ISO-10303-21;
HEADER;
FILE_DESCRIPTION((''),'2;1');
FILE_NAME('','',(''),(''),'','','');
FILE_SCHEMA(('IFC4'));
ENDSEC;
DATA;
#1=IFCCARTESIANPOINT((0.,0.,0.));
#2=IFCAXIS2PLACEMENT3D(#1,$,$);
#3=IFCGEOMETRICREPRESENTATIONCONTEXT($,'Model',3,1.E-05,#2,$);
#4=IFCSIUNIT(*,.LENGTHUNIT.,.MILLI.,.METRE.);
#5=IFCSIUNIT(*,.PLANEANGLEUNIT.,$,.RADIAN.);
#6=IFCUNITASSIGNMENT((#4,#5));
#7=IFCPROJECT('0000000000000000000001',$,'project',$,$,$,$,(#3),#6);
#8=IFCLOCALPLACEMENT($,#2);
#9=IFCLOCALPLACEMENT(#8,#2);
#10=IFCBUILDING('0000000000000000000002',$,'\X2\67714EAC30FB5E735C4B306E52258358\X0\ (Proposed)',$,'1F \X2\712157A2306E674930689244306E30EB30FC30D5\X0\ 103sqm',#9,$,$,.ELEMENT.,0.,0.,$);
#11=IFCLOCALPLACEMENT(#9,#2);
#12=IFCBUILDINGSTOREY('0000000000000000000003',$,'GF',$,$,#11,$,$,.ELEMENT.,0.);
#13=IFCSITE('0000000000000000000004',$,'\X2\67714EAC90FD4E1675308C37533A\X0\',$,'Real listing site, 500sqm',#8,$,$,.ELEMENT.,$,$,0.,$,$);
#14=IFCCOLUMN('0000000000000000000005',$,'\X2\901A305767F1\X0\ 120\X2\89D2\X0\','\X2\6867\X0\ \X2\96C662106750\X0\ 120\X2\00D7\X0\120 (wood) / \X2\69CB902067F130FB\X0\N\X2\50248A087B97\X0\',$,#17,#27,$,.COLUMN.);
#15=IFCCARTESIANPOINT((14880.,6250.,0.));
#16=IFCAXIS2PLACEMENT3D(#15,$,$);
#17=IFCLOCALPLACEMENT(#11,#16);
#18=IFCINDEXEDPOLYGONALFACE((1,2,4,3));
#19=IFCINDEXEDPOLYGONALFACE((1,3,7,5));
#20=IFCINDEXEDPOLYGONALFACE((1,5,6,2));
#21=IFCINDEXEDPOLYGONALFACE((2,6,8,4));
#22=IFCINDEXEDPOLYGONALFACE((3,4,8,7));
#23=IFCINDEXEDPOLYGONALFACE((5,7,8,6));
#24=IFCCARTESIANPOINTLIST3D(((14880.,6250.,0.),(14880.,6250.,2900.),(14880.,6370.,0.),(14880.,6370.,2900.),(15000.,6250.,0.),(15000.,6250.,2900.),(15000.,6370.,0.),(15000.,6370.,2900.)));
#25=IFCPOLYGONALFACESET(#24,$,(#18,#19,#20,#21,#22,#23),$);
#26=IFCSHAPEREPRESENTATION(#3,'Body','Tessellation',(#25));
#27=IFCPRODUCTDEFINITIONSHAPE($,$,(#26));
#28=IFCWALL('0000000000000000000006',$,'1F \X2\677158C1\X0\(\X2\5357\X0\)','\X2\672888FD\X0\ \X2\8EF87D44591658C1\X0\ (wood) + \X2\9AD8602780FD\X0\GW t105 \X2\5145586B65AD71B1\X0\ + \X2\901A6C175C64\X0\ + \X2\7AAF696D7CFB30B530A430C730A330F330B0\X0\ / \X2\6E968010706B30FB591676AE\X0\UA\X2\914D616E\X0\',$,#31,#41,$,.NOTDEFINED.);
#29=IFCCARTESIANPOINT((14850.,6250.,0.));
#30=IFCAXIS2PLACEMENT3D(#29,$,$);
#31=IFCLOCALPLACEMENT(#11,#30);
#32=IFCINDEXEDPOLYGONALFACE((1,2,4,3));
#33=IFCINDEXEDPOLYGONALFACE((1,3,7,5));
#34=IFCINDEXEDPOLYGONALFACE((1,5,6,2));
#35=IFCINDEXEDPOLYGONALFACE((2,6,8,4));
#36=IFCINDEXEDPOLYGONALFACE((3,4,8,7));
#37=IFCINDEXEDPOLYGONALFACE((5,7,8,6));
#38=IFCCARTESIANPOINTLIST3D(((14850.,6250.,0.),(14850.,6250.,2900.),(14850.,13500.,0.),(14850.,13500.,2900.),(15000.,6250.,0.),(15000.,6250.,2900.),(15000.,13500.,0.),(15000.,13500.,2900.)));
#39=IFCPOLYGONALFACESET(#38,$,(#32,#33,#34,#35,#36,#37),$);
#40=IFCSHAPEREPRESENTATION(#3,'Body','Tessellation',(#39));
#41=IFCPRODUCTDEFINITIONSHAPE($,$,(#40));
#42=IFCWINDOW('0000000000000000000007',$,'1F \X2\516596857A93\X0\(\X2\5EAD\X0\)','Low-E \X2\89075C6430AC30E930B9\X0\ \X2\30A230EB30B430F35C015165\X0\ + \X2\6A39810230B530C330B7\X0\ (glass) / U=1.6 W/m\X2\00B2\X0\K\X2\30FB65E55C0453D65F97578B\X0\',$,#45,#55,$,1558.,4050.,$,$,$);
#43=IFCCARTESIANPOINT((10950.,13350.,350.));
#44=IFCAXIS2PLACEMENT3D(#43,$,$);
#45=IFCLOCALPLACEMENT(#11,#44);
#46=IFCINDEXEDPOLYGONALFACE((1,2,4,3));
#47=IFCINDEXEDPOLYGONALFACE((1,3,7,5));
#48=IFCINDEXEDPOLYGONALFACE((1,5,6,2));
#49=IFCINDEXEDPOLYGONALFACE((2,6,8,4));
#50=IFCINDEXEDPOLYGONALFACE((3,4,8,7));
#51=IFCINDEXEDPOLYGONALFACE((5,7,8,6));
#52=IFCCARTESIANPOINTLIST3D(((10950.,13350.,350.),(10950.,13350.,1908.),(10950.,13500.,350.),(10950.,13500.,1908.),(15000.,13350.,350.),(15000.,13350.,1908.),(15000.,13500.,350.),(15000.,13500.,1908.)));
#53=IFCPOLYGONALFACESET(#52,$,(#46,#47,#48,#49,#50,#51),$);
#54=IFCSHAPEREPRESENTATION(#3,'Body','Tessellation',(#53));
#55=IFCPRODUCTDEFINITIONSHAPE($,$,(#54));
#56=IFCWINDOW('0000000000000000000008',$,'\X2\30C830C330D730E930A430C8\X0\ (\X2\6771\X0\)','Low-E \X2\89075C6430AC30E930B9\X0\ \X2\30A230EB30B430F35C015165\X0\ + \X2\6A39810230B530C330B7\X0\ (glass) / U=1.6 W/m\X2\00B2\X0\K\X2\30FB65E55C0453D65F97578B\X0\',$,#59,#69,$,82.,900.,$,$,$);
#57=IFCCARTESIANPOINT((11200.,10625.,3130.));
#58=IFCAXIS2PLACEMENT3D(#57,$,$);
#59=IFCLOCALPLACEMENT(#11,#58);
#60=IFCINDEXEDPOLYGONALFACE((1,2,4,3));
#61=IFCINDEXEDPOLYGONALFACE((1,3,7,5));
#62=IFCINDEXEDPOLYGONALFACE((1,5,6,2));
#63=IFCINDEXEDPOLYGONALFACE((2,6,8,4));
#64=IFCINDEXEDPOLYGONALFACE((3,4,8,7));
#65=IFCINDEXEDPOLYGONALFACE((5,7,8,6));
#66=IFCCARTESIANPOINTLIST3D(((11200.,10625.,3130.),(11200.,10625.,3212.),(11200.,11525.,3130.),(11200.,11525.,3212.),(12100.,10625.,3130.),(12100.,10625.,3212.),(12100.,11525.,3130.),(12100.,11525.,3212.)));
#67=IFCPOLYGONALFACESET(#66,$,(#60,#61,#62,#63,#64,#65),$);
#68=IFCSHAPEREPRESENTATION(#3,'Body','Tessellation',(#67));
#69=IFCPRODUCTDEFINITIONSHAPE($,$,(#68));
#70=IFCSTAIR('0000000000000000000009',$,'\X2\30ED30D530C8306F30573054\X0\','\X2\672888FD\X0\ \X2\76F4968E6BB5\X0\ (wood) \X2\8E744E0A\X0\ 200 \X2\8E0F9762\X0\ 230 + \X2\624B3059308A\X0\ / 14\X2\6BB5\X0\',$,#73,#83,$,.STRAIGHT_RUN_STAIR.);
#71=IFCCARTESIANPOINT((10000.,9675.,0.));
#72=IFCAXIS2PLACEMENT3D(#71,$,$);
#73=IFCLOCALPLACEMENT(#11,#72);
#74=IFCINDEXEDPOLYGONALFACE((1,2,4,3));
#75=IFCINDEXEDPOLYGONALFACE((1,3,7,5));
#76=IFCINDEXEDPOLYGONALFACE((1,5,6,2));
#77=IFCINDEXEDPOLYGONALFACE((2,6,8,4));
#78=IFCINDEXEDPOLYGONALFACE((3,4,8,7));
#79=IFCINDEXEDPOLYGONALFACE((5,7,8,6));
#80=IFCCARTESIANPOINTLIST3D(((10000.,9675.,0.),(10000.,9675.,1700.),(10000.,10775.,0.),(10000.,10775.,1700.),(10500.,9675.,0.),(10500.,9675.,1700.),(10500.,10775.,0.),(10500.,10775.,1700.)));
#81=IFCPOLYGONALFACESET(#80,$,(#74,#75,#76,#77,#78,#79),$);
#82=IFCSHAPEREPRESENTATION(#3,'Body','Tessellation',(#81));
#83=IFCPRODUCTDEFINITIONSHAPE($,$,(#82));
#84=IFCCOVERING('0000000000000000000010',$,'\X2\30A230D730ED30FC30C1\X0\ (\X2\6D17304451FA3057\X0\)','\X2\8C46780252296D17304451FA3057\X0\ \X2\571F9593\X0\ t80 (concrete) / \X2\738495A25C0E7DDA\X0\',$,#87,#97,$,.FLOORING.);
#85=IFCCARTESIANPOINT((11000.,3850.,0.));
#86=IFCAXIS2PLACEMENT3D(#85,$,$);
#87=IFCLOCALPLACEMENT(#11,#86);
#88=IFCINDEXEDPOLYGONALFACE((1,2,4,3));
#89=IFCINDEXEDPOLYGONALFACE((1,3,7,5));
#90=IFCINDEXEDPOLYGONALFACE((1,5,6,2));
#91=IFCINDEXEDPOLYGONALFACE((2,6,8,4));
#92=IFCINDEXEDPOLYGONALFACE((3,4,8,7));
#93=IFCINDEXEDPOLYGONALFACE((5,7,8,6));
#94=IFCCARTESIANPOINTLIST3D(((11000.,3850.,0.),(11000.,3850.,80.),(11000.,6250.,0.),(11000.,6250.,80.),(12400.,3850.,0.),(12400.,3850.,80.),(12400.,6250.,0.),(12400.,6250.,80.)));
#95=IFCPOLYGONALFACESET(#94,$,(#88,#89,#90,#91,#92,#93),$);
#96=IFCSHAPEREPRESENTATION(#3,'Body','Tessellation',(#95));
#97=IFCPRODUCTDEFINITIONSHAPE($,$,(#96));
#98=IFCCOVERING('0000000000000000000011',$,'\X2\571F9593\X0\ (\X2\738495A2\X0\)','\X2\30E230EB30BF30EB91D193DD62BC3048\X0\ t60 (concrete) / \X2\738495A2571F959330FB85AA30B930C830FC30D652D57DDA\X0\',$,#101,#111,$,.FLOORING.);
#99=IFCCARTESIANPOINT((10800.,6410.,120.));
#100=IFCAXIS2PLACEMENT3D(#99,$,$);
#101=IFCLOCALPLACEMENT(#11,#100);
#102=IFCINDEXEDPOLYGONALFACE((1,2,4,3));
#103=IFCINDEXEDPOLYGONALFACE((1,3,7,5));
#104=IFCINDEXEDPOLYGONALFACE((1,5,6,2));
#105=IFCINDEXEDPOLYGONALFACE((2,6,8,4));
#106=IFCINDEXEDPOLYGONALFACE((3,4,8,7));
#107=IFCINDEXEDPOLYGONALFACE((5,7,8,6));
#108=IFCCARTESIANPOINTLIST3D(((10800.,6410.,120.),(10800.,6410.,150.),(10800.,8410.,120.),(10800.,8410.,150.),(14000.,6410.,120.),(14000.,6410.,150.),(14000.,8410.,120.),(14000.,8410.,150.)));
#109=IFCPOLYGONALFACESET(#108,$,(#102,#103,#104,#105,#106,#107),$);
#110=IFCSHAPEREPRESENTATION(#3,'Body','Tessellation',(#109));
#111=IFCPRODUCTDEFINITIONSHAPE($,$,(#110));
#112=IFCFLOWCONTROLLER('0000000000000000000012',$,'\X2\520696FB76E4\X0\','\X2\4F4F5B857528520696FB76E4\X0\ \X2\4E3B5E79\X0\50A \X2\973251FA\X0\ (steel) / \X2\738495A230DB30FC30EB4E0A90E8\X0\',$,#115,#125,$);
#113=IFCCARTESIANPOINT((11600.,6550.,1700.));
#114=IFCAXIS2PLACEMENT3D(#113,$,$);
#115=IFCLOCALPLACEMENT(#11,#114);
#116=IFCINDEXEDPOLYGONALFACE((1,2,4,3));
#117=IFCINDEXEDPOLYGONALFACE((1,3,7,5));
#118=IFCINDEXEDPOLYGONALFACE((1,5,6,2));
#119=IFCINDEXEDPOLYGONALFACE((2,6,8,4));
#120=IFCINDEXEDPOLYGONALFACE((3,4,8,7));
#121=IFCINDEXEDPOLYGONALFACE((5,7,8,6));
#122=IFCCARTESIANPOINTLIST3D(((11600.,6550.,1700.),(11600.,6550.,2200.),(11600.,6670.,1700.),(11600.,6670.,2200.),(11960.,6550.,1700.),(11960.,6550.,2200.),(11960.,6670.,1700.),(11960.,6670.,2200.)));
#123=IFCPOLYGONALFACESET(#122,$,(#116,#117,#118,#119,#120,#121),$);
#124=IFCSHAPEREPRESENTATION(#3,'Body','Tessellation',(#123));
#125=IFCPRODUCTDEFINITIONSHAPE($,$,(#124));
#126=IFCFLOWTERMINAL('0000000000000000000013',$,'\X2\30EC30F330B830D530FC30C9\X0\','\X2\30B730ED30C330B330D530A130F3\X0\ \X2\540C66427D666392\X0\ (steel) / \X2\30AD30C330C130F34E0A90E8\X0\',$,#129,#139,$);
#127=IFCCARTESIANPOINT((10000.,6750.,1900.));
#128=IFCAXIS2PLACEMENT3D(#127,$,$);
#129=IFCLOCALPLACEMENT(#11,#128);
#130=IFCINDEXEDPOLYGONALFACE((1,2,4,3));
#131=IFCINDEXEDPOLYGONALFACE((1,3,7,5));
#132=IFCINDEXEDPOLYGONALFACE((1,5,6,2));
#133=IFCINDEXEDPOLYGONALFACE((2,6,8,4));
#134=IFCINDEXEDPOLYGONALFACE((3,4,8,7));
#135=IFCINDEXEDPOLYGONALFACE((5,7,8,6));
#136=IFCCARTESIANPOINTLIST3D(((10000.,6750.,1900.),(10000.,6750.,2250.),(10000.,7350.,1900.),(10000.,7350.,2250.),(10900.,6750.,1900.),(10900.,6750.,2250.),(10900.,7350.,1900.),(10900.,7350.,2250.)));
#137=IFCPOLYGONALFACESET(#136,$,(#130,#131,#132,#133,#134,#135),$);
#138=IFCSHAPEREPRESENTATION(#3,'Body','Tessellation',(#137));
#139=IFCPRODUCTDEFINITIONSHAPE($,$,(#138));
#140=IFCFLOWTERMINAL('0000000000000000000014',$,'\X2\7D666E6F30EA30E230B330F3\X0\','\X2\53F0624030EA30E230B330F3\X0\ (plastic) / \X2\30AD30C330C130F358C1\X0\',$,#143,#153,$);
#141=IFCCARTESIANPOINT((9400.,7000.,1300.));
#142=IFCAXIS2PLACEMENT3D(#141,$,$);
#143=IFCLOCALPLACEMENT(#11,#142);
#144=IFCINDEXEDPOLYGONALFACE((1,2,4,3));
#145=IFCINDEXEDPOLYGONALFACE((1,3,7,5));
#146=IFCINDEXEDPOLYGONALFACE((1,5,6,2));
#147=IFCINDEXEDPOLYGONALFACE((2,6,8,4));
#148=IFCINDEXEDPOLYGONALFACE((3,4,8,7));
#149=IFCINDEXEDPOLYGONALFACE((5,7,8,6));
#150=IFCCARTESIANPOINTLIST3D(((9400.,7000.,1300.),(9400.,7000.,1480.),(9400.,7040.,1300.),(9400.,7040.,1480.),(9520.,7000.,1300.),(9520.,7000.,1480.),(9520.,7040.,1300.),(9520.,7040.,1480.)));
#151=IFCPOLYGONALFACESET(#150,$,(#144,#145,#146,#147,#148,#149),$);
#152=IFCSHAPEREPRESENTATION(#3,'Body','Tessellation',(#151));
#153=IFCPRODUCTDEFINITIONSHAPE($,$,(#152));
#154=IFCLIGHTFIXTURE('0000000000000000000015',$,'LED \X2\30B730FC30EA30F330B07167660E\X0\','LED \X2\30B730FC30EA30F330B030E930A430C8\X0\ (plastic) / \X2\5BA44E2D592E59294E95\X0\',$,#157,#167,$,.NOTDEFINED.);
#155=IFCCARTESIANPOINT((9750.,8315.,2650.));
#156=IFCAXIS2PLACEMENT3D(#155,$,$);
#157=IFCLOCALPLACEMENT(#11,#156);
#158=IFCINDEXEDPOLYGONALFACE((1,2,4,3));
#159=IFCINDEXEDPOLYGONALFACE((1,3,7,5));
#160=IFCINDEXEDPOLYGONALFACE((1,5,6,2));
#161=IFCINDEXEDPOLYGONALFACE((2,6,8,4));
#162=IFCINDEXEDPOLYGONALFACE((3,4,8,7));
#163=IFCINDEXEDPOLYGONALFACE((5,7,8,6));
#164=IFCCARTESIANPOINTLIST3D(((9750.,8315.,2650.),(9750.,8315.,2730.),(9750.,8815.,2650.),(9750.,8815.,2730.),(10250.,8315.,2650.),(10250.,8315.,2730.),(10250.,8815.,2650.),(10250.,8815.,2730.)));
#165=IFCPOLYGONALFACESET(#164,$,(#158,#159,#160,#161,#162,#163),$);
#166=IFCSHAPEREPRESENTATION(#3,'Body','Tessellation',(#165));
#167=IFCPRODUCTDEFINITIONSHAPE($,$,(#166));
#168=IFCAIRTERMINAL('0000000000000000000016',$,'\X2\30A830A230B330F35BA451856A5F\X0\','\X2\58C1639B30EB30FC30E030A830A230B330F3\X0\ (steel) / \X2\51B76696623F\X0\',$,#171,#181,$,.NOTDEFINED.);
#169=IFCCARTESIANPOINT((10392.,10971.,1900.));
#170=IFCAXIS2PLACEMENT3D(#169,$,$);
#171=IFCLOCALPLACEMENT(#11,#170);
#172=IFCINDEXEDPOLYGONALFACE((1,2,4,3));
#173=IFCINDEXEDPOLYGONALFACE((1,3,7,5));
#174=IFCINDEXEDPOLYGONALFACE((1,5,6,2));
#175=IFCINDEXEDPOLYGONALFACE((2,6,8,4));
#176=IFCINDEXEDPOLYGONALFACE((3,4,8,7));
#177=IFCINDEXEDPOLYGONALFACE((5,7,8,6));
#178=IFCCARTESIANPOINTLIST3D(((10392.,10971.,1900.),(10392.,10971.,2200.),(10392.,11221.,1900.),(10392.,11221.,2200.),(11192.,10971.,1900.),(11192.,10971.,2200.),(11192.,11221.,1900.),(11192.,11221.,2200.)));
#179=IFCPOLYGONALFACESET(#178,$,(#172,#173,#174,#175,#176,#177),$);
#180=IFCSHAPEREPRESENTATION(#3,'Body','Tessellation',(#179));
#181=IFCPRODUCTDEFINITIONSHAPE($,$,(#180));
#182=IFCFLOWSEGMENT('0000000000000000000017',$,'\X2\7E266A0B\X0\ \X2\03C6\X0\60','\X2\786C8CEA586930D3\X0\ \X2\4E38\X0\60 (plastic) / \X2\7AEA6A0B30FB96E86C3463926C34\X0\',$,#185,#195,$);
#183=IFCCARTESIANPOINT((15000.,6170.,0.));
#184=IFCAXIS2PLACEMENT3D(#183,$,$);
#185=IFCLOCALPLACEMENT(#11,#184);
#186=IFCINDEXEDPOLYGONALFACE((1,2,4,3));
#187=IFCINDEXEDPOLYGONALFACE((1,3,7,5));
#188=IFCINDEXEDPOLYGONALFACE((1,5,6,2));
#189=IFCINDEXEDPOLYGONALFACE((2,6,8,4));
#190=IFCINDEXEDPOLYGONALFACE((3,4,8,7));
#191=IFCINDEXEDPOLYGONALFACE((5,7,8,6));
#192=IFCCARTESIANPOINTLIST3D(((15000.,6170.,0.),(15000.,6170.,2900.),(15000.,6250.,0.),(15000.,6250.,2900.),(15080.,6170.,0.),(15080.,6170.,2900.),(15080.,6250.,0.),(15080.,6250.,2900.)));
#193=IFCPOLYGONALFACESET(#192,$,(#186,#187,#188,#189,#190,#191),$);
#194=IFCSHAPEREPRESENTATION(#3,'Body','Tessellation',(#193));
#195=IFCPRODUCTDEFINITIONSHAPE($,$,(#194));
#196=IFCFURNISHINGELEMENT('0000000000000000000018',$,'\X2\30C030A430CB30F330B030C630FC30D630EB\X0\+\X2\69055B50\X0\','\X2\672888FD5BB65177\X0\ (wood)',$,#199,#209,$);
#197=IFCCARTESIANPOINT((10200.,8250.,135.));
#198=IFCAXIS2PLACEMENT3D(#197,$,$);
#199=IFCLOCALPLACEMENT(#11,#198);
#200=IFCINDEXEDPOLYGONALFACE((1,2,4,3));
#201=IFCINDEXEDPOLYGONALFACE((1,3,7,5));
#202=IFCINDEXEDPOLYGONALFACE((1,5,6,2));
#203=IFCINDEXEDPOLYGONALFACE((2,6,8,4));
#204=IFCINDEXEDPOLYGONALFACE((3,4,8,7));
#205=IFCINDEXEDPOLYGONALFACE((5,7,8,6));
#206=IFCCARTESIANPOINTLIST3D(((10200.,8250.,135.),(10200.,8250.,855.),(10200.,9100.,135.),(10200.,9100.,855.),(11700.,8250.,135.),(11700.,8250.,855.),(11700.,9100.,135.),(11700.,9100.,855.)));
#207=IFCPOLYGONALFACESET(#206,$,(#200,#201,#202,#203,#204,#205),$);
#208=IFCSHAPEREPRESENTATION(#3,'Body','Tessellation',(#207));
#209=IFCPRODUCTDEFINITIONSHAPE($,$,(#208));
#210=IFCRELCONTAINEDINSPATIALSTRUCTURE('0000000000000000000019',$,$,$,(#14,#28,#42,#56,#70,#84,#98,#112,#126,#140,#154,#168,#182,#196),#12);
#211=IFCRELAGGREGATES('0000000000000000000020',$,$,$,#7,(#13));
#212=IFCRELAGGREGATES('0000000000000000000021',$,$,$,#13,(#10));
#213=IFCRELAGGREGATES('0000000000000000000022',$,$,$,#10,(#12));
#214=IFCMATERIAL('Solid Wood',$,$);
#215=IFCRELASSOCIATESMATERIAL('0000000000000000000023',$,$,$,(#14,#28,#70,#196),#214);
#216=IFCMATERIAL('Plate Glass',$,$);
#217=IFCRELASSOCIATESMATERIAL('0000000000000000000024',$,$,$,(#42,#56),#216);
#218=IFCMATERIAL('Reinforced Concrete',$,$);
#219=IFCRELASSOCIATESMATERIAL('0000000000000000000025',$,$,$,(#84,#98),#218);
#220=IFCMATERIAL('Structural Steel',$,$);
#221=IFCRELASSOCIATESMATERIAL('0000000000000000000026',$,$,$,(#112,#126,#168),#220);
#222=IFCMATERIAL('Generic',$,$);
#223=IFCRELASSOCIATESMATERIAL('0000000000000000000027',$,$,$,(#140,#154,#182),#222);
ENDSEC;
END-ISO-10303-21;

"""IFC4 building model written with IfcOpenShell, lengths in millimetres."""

from ifc_helpers import new_model, si_unit, frame, frame_2d, origin, place, context, project, spatial, rectangle, extrude, material, element, fill, save


model = new_model("IFC4")

# Units and contexts
model_context = context("Model", 3, precision=1e-05, world=origin())
ifc_project = project(units=[si_unit("LENGTHUNIT", "METRE", prefix="MILLI"), si_unit("PLANEANGLEUNIT", "RADIAN")], contexts=[model_context])

# Site, building, storey
site_placement = place(None, origin())
site = spatial("IfcSite", under=ifc_project, at=site_placement, Name="東京都世田谷区", ObjectType="Real listing site, 500sqm", CompositionType="ELEMENT", RefElevation=0.0)
building_placement = place(site_placement, origin())
building = spatial("IfcBuilding", under=site, at=building_placement, Name="東京・平屋の別荘 (Proposed)", ObjectType="1F 無垢の杉と鉄のルーフ 103sqm", CompositionType="ELEMENT", ElevationOfRefHeight=0.0, ElevationOfTerrain=0.0)
storey_placement = place(building_placement, origin())
storey = spatial("IfcBuildingStorey", under=building, at=storey_placement, Name="GF", CompositionType="ELEMENT", Elevation=0.0)

# Column
ifc_material_1 = material(Name="Solid Wood")
column_1_placement = place(storey_placement, frame((14880.0, 6250.0, 0.0)))
element("IfcColumn", 1, at=column_1_placement, inside=storey, material=ifc_material_1, Name="通し柱 120角", Description="桧 集成材 120×120 (wood) / 構造柱・N値計算", PredefinedType="COLUMN", context=model_context, shape_type="SweptSolid", body=[
    extrude(rectangle(XDim=120.0, YDim=120.0, at=frame_2d((60.0, 60.0))), frame((14880.0, 6250.0, 0.0)), (0.0, 0.0, 1.0), 2900.0),
])

# Wall, opening, window
wall_1_placement = place(storey_placement, frame((14850.0, 6250.0, 0.0)))
wall_1 = element("IfcWall", 2, at=wall_1_placement, inside=storey, material=ifc_material_1, Name="1F 東壁(南)", Description="木製 軸組外壁 (wood) + 高性能GW t105 充填断熱 + 通気層 + 窯業系サイディング / 準耐火・外皮UA配慮", PredefinedType="NOTDEFINED", context=model_context, shape_type="SweptSolid", body=[
    extrude(rectangle(XDim=150.0, YDim=7250.0, at=frame_2d((75.0, 3625.0))), frame((14850.0, 6250.0, 0.0)), (0.0, 0.0, 1.0), 2900.0),
])
opening_placement = place(storey_placement, frame((10950.0, 13350.0, 350.0)))
opening = element("IfcOpeningElement", 3, at=opening_placement, cuts=wall_1, PredefinedType="NOTDEFINED", context=model_context, shape_type="SweptSolid", body=[
    extrude(rectangle(XDim=4050.0, YDim=150.0, at=frame_2d((2025.0, 75.0))), frame((10950.0, 13350.0, 350.0)), (0.0, 0.0, 1.0), 1558.0),
])
ifc_material_2 = material(Name="Plate Glass")
window_1_placement = place(storey_placement, frame((10950.0, 13350.0, 350.0)))
window_1 = element("IfcWindow", 4, at=window_1_placement, inside=storey, material=ifc_material_2, Name="1F 入隅窓(庭)", Description="Low-E 複層ガラス アルゴン封入 + 樹脂サッシ (glass) / U=1.6 W/m²K・日射取得型", OverallHeight=1558.0, OverallWidth=4050.0, context=model_context, shape_type="SweptSolid", body=[
    extrude(rectangle(XDim=4050.0, YDim=150.0, at=frame_2d((2025.0, 75.0))), frame((10950.0, 13350.0, 350.0)), (0.0, 0.0, 1.0), 1558.0),
])
fill(opening, window_1)

# Window
window_2_placement = place(storey_placement, frame((11200.0, 10625.0, 3130.0)))
element("IfcWindow", 5, at=window_2_placement, inside=storey, material=ifc_material_2, Name="トップライト (東)", Description="Low-E 複層ガラス アルゴン封入 + 樹脂サッシ (glass) / U=1.6 W/m²K・日射取得型", OverallHeight=82.0, OverallWidth=900.0, context=model_context, shape_type="SweptSolid", body=[
    extrude(rectangle(XDim=900.0, YDim=900.0, at=frame_2d((450.0, 450.0))), frame((11200.0, 10625.0, 3130.0)), (0.0, 0.0, 1.0), 82.0),
])

# Stair
stair_placement = place(storey_placement, frame((10000.0, 9675.0, 0.0)))
element("IfcStair", 6, at=stair_placement, inside=storey, material=ifc_material_1, Name="ロフトはしご", Description="木製 直階段 (wood) 蹴上 200 踏面 230 + 手すり / 14段", PredefinedType="STRAIGHT_RUN_STAIR", context=model_context, shape_type="SweptSolid", body=[
    extrude(rectangle(XDim=500.0, YDim=1100.0, at=frame_2d((250.0, 550.0))), frame((10000.0, 9675.0, 0.0)), (0.0, 0.0, 1.0), 1700.0),
])

# Coverings
ifc_material_3 = material(Name="Reinforced Concrete")
covering_1_placement = place(storey_placement, frame((11000.0, 3850.0, 0.0)))
element("IfcCovering", 7, at=covering_1_placement, inside=storey, material=ifc_material_3, Name="アプローチ (洗い出し)", Description="豆砂利洗い出し 土間 t80 (concrete) / 玄関導線", PredefinedType="FLOORING", context=model_context, shape_type="SweptSolid", body=[
    extrude(rectangle(XDim=1400.0, YDim=2400.0, at=frame_2d((700.0, 1200.0))), frame((11000.0, 3850.0, 0.0)), (0.0, 0.0, 1.0), 80.0),
])
covering_2_placement = place(storey_placement, frame((10800.0, 6410.0, 120.0)))
element("IfcCovering", 8, at=covering_2_placement, inside=storey, material=ifc_material_3, Name="土間 (玄関)", Description="モルタル金鏝押え t60 (concrete) / 玄関土間・薪ストーブ動線", PredefinedType="FLOORING", context=model_context, shape_type="SweptSolid", body=[
    extrude(rectangle(XDim=3200.0, YDim=2000.0, at=frame_2d((1600.0, 1000.0))), frame((10800.0, 6410.0, 120.0)), (0.0, 0.0, 1.0), 30.0),
])

# Flow controller
ifc_material_4 = material(Name="Structural Steel")
flow_controller_placement = place(storey_placement, frame((11600.0, 6550.0, 1700.0)))
element("IfcFlowController", 9, at=flow_controller_placement, inside=storey, material=ifc_material_4, Name="分電盤", Description="住宅用分電盤 主幹50A 露出 (steel) / 玄関ホール上部", context=model_context, shape_type="SweptSolid", body=[
    extrude(rectangle(XDim=360.0, YDim=120.0, at=frame_2d((180.0, 60.0))), frame((11600.0, 6550.0, 1700.0)), (0.0, 0.0, 1.0), 500.0),
])

# Flow terminals
flow_terminal_1_placement = place(storey_placement, frame((10000.0, 6750.0, 1900.0)))
element("IfcFlowTerminal", 10, at=flow_terminal_1_placement, inside=storey, material=ifc_material_4, Name="レンジフード", Description="シロッコファン 同時給排 (steel) / キッチン上部", context=model_context, shape_type="SweptSolid", body=[
    extrude(rectangle(XDim=900.0, YDim=600.0, at=frame_2d((450.0, 300.0))), frame((10000.0, 6750.0, 1900.0)), (0.0, 0.0, 1.0), 350.0),
])
ifc_material_5 = material(Name="Generic")
flow_terminal_2_placement = place(storey_placement, frame((9400.0, 7000.0, 1300.0)))
element("IfcFlowTerminal", 11, at=flow_terminal_2_placement, inside=storey, material=ifc_material_5, Name="給湯リモコン", Description="台所リモコン (plastic) / キッチン壁", context=model_context, shape_type="SweptSolid", body=[
    extrude(rectangle(XDim=120.0, YDim=40.0, at=frame_2d((60.0, 20.0))), frame((9400.0, 7000.0, 1300.0)), (0.0, 0.0, 1.0), 180.0),
])

# Light fixture
light_fixture_placement = place(storey_placement, frame((9750.0, 8315.0, 2650.0)))
element("IfcLightFixture", 12, at=light_fixture_placement, inside=storey, material=ifc_material_5, Name="LED シーリング照明", Description="LED シーリングライト (plastic) / 室中央天井", PredefinedType="NOTDEFINED", context=model_context, shape_type="SweptSolid", body=[
    extrude(rectangle(XDim=500.0, YDim=500.0, at=frame_2d((250.0, 250.0))), frame((9750.0, 8315.0, 2650.0)), (0.0, 0.0, 1.0), 80.0),
])

# Air terminal
air_terminal_placement = place(storey_placement, frame((10392.0, 10971.0, 1900.0)))
element("IfcAirTerminal", 13, at=air_terminal_placement, inside=storey, material=ifc_material_4, Name="エアコン室内機", Description="壁掛ルームエアコン (steel) / 冷暖房", PredefinedType="NOTDEFINED", context=model_context, shape_type="SweptSolid", body=[
    extrude(rectangle(XDim=800.0, YDim=250.0, at=frame_2d((400.0, 125.0))), frame((10392.0, 10971.0, 1900.0)), (0.0, 0.0, 1.0), 300.0),
])

# Flow segment
flow_segment_placement = place(storey_placement, frame((15000.0, 6170.0, 0.0)))
element("IfcFlowSegment", 14, at=flow_segment_placement, inside=storey, material=ifc_material_5, Name="縦樋 φ60", Description="硬質塩ビ 丸60 (plastic) / 竪樋・雨水排水", context=model_context, shape_type="SweptSolid", body=[
    extrude(rectangle(XDim=80.0, YDim=80.0, at=frame_2d((40.0, 40.0))), frame((15000.0, 6170.0, 0.0)), (0.0, 0.0, 1.0), 2900.0),
])

# Furnishing element
furnishing_1_placement = place(storey_placement, frame((10200.0, 8250.0, 135.0)))
element("IfcFurnishingElement", 15, at=furnishing_1_placement, inside=storey, material=ifc_material_1, Name="ダイニングテーブル+椅子", Description="木製家具 (wood)", context=model_context, shape_type="SweptSolid", body=[
    extrude(rectangle(XDim=1500.0, YDim=850.0, at=frame_2d((750.0, 425.0))), frame((10200.0, 8250.0, 135.0)), (0.0, 0.0, 1.0), 720.0),
])

save(model, "model.ifc")
